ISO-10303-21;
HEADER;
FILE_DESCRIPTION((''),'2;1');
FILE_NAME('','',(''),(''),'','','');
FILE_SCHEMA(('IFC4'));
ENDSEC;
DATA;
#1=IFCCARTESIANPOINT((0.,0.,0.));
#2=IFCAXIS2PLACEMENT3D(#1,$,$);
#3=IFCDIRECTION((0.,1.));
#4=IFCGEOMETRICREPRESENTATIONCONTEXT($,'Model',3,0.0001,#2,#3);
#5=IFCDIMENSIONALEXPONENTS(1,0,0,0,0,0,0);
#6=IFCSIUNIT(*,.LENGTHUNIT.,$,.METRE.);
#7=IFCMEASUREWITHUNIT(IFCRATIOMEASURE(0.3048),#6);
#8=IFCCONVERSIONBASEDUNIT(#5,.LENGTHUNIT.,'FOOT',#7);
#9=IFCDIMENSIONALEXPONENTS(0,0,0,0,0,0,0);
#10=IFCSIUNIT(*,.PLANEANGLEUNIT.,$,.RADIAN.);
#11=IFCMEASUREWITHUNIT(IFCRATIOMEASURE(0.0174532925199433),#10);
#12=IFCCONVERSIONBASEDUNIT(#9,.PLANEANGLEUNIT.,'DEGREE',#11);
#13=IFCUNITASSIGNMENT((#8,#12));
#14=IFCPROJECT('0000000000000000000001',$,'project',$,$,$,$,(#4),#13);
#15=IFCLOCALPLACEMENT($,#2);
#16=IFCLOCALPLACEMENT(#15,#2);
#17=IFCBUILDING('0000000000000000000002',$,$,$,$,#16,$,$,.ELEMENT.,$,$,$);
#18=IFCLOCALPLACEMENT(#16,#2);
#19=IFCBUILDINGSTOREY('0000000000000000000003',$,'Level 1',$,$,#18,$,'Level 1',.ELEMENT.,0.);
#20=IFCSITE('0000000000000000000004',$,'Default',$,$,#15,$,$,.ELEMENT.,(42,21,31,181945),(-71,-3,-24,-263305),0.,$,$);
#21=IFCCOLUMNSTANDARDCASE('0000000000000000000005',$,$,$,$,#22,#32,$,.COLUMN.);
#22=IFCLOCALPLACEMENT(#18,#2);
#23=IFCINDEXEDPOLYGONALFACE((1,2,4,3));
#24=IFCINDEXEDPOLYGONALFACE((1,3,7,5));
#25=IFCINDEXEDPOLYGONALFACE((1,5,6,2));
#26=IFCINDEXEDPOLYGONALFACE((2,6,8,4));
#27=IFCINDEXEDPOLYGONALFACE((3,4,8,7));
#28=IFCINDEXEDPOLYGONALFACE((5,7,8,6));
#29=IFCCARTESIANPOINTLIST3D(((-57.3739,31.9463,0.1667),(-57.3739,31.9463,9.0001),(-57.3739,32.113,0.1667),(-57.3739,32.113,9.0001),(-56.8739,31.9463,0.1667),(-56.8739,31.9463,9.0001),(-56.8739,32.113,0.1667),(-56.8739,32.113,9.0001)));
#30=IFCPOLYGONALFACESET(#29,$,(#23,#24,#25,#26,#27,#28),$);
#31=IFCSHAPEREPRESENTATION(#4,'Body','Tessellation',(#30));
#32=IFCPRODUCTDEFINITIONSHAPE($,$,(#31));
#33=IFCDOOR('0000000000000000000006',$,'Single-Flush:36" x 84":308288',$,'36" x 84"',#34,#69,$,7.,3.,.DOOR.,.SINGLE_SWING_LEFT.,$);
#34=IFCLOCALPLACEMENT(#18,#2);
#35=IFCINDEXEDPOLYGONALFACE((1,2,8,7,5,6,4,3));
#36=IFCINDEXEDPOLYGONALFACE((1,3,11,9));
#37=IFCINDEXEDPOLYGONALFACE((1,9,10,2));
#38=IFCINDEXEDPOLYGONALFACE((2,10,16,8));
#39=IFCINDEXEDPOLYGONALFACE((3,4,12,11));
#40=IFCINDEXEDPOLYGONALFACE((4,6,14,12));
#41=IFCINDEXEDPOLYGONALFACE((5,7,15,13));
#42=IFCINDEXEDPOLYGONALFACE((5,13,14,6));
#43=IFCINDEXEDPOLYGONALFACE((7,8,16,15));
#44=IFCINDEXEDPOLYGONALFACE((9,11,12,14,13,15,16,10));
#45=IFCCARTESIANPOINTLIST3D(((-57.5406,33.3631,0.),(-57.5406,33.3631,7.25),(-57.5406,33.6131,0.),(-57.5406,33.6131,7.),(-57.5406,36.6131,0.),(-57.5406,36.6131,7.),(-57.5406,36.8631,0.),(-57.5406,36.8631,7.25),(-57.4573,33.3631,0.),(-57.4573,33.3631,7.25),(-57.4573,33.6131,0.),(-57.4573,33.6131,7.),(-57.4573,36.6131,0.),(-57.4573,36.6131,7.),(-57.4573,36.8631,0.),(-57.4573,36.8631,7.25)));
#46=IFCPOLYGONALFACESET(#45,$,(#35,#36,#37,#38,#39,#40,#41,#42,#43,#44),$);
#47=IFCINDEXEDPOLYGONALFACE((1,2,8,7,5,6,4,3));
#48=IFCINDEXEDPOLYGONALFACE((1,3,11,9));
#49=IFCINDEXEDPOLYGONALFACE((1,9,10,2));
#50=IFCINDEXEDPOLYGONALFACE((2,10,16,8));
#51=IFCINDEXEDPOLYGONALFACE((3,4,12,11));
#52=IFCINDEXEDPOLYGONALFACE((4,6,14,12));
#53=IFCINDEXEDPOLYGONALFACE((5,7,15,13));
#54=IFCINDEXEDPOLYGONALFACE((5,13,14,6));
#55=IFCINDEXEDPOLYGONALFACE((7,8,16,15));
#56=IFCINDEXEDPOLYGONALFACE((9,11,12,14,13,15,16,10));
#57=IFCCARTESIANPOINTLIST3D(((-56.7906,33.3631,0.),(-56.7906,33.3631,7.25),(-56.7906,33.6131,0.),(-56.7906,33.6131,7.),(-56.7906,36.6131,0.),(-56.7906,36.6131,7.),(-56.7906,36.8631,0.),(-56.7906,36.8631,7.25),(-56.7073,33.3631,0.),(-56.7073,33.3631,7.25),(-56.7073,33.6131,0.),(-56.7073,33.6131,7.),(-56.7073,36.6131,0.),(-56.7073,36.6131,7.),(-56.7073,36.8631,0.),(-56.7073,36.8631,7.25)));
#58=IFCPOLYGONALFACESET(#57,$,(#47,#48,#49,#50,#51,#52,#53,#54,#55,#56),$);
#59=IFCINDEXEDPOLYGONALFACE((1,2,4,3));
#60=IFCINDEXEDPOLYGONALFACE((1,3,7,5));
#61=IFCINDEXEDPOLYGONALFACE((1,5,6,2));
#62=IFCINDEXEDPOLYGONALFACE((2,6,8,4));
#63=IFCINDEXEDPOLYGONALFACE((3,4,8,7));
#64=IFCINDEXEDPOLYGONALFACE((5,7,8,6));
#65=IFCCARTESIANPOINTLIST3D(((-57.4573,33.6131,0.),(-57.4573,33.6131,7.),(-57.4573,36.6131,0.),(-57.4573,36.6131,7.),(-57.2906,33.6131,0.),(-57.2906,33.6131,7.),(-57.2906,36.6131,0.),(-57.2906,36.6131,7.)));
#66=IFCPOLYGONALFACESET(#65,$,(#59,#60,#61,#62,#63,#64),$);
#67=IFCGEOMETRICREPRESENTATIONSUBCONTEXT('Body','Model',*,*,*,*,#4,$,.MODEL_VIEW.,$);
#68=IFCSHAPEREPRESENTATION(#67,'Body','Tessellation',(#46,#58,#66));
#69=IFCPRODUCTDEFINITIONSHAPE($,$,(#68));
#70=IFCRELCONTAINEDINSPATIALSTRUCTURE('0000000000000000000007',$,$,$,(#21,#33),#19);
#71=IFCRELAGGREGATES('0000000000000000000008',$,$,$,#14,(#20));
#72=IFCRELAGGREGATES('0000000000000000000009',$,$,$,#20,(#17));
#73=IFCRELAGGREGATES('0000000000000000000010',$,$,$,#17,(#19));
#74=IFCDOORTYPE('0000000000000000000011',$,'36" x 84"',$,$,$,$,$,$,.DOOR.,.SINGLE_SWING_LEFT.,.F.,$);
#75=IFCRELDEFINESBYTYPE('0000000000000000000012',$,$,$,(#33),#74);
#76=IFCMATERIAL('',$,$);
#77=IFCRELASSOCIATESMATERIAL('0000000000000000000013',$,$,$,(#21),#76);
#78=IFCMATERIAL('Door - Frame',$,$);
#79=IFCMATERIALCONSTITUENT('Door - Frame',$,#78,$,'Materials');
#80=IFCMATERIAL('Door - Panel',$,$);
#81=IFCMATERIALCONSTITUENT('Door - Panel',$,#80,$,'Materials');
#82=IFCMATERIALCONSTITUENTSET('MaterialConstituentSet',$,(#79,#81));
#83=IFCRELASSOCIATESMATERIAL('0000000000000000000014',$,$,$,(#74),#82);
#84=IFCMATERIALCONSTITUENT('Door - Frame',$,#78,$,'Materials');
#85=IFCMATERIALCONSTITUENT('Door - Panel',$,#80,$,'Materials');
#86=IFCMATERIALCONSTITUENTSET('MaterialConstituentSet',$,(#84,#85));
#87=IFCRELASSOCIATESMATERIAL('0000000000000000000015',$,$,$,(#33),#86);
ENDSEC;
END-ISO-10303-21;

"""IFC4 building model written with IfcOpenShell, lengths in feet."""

from ifc_helpers import new_model, entity, si_unit, converted_unit, direction, frame, frame_2d, origin, place, context, subcontext, project, spatial, polyline, rectangle, outline, extrude, source, transform, mapped, material, constituent, constituent_set, type_object, type_shapes, element, save


model = new_model("IFC4")

# Units and contexts
model_context = context("Model", 3, precision=0.0001, world=origin(), true_north=direction((0.0, 1.0)))
body_context = subcontext(model_context, "Body", "Model", "MODEL_VIEW")
ifc_project = project(units=[converted_unit("LENGTHUNIT", "FOOT", entity("IfcRatioMeasure", 0.3048), si_unit("LENGTHUNIT", "METRE"), dimensions=[1, 0, 0, 0, 0, 0, 0]), converted_unit("PLANEANGLEUNIT", "DEGREE", entity("IfcRatioMeasure", 0.0174532925199433), si_unit("PLANEANGLEUNIT", "RADIAN"), dimensions=[0, 0, 0, 0, 0, 0, 0])], contexts=[model_context])

# Site, building, storey
site_placement = place(None, origin())
site = spatial("IfcSite", under=ifc_project, at=site_placement, Name="Default", CompositionType="ELEMENT", RefLatitude=(42, 21, 31, 181945), RefLongitude=(-71, -3, -24, -263305), RefElevation=0.0)
building_placement = place(site_placement, origin())
building = spatial("IfcBuilding", under=site, at=building_placement, CompositionType="ELEMENT")
storey_placement = place(building_placement, origin())
storey = spatial("IfcBuildingStorey", under=building, at=storey_placement, Name="Level 1", LongName="Level 1", CompositionType="ELEMENT", Elevation=0.0)

# Column
ifc_material_1 = material(Name="")
placement_1 = place(storey_placement, frame((-57.1239, 31.9464, 0.0), z_axis=(0.0, 0.0, 1.0), x_axis=(0.0, 1.0, 0.0)))
for number, where, z_axis, x_axis in (
    (1, (0.0833, 0.0, 0.1667), (0.0, 0.0, 1.0), (1.0, 0.0, 0.0)),
):
    element("IfcColumnStandardCase", number, at=place(placement_1, frame(where, z_axis=z_axis, x_axis=x_axis)), inside=storey, material=ifc_material_1, PredefinedType="COLUMN", context=model_context, shape_type="SweptSolid", body=[
        extrude(rectangle(XDim=0.1667, YDim=0.5), origin(), (0.0, 0.0, 1.0), 8.8334),
    ])

# Door
ifc_material_2 = material(Name="Door - Frame")
ifc_constituent_1 = constituent(ifc_material_2, Name="Door - Frame", Category="Materials")
ifc_material_3 = material(Name="Door - Panel")
ifc_constituent_2 = constituent(ifc_material_3, Name="Door - Panel", Category="Materials")
ifc_constituent_set_1 = constituent_set(constituents=[ifc_constituent_1, ifc_constituent_2], Name="MaterialConstituentSet")
ifc_constituent_3 = constituent(ifc_material_2, Name="Door - Frame", Category="Materials")
ifc_constituent_4 = constituent(ifc_material_3, Name="Door - Panel", Category="Materials")
ifc_constituent_set_2 = constituent_set(constituents=[ifc_constituent_3, ifc_constituent_4], Name="MaterialConstituentSet")
door_type = type_object("IfcDoorType", Name="36\" x 84\"", OperationType="SINGLE_SWING_LEFT", ParameterTakesPrecedence=False, PredefinedType="DOOR", material=ifc_constituent_set_2)
shared_shape = source(origin(), body_context, "Body", "SweptSolid", [
    extrude(outline(polyline([(-1.75, -3.6875), (1.75, -3.6875), (1.75, 3.5625), (1.5, 3.5625), (1.5, -3.4375), (-1.5, -3.4375), (-1.5, 3.5625), (-1.75, 3.5625), (-1.75, -3.6875)])), frame((1.5, 0.75, 3.5625), z_axis=(0.0, -1.0, 0.0), x_axis=(-1.0, 0.0, 0.0)), (0.0, 0.0, 1.0), 0.0833),
    extrude(outline(polyline([(-3.6875, -1.75), (3.5625, -1.75), (3.5625, -1.5), (-3.4375, -1.5), (-3.4375, 1.5), (3.5625, 1.5), (3.5625, 1.75), (-3.6875, 1.75), (-3.6875, -1.75)])), frame((1.5, 0.0, 3.5625), z_axis=(0.0, -1.0, 0.0), x_axis=(0.0, 0.0, -1.0)), (0.0, 0.0, 1.0), 0.0833),
    extrude(rectangle(XDim=3.0, YDim=0.1667, at=frame_2d((0.0, 0.0), x_axis=(1.0, 0.0))), frame((1.5, 0.5833, 0.0)), (0.0, 0.0, 1.0), 7.0),
])
type_shapes(door_type, [shared_shape])
placement_2 = place(placement_1, frame((1.6667, -0.3333, 0.0)))
door_placement = place(placement_2, origin())
element("IfcDoor", 2, at=door_placement, inside=storey, type_object=door_type, material=ifc_constituent_set_1, Name="Single-Flush:36\" x 84\":308288", ObjectType="36\" x 84\"", OperationType="SINGLE_SWING_LEFT", OverallHeight=7.0, OverallWidth=3.0, PredefinedType="DOOR", context=body_context, shape_type="MappedRepresentation", body=[
    mapped(shared_shape, transform((0.0, 0.0, 0.0), scale=1.0)),
])

save(model, "model.ifc")
